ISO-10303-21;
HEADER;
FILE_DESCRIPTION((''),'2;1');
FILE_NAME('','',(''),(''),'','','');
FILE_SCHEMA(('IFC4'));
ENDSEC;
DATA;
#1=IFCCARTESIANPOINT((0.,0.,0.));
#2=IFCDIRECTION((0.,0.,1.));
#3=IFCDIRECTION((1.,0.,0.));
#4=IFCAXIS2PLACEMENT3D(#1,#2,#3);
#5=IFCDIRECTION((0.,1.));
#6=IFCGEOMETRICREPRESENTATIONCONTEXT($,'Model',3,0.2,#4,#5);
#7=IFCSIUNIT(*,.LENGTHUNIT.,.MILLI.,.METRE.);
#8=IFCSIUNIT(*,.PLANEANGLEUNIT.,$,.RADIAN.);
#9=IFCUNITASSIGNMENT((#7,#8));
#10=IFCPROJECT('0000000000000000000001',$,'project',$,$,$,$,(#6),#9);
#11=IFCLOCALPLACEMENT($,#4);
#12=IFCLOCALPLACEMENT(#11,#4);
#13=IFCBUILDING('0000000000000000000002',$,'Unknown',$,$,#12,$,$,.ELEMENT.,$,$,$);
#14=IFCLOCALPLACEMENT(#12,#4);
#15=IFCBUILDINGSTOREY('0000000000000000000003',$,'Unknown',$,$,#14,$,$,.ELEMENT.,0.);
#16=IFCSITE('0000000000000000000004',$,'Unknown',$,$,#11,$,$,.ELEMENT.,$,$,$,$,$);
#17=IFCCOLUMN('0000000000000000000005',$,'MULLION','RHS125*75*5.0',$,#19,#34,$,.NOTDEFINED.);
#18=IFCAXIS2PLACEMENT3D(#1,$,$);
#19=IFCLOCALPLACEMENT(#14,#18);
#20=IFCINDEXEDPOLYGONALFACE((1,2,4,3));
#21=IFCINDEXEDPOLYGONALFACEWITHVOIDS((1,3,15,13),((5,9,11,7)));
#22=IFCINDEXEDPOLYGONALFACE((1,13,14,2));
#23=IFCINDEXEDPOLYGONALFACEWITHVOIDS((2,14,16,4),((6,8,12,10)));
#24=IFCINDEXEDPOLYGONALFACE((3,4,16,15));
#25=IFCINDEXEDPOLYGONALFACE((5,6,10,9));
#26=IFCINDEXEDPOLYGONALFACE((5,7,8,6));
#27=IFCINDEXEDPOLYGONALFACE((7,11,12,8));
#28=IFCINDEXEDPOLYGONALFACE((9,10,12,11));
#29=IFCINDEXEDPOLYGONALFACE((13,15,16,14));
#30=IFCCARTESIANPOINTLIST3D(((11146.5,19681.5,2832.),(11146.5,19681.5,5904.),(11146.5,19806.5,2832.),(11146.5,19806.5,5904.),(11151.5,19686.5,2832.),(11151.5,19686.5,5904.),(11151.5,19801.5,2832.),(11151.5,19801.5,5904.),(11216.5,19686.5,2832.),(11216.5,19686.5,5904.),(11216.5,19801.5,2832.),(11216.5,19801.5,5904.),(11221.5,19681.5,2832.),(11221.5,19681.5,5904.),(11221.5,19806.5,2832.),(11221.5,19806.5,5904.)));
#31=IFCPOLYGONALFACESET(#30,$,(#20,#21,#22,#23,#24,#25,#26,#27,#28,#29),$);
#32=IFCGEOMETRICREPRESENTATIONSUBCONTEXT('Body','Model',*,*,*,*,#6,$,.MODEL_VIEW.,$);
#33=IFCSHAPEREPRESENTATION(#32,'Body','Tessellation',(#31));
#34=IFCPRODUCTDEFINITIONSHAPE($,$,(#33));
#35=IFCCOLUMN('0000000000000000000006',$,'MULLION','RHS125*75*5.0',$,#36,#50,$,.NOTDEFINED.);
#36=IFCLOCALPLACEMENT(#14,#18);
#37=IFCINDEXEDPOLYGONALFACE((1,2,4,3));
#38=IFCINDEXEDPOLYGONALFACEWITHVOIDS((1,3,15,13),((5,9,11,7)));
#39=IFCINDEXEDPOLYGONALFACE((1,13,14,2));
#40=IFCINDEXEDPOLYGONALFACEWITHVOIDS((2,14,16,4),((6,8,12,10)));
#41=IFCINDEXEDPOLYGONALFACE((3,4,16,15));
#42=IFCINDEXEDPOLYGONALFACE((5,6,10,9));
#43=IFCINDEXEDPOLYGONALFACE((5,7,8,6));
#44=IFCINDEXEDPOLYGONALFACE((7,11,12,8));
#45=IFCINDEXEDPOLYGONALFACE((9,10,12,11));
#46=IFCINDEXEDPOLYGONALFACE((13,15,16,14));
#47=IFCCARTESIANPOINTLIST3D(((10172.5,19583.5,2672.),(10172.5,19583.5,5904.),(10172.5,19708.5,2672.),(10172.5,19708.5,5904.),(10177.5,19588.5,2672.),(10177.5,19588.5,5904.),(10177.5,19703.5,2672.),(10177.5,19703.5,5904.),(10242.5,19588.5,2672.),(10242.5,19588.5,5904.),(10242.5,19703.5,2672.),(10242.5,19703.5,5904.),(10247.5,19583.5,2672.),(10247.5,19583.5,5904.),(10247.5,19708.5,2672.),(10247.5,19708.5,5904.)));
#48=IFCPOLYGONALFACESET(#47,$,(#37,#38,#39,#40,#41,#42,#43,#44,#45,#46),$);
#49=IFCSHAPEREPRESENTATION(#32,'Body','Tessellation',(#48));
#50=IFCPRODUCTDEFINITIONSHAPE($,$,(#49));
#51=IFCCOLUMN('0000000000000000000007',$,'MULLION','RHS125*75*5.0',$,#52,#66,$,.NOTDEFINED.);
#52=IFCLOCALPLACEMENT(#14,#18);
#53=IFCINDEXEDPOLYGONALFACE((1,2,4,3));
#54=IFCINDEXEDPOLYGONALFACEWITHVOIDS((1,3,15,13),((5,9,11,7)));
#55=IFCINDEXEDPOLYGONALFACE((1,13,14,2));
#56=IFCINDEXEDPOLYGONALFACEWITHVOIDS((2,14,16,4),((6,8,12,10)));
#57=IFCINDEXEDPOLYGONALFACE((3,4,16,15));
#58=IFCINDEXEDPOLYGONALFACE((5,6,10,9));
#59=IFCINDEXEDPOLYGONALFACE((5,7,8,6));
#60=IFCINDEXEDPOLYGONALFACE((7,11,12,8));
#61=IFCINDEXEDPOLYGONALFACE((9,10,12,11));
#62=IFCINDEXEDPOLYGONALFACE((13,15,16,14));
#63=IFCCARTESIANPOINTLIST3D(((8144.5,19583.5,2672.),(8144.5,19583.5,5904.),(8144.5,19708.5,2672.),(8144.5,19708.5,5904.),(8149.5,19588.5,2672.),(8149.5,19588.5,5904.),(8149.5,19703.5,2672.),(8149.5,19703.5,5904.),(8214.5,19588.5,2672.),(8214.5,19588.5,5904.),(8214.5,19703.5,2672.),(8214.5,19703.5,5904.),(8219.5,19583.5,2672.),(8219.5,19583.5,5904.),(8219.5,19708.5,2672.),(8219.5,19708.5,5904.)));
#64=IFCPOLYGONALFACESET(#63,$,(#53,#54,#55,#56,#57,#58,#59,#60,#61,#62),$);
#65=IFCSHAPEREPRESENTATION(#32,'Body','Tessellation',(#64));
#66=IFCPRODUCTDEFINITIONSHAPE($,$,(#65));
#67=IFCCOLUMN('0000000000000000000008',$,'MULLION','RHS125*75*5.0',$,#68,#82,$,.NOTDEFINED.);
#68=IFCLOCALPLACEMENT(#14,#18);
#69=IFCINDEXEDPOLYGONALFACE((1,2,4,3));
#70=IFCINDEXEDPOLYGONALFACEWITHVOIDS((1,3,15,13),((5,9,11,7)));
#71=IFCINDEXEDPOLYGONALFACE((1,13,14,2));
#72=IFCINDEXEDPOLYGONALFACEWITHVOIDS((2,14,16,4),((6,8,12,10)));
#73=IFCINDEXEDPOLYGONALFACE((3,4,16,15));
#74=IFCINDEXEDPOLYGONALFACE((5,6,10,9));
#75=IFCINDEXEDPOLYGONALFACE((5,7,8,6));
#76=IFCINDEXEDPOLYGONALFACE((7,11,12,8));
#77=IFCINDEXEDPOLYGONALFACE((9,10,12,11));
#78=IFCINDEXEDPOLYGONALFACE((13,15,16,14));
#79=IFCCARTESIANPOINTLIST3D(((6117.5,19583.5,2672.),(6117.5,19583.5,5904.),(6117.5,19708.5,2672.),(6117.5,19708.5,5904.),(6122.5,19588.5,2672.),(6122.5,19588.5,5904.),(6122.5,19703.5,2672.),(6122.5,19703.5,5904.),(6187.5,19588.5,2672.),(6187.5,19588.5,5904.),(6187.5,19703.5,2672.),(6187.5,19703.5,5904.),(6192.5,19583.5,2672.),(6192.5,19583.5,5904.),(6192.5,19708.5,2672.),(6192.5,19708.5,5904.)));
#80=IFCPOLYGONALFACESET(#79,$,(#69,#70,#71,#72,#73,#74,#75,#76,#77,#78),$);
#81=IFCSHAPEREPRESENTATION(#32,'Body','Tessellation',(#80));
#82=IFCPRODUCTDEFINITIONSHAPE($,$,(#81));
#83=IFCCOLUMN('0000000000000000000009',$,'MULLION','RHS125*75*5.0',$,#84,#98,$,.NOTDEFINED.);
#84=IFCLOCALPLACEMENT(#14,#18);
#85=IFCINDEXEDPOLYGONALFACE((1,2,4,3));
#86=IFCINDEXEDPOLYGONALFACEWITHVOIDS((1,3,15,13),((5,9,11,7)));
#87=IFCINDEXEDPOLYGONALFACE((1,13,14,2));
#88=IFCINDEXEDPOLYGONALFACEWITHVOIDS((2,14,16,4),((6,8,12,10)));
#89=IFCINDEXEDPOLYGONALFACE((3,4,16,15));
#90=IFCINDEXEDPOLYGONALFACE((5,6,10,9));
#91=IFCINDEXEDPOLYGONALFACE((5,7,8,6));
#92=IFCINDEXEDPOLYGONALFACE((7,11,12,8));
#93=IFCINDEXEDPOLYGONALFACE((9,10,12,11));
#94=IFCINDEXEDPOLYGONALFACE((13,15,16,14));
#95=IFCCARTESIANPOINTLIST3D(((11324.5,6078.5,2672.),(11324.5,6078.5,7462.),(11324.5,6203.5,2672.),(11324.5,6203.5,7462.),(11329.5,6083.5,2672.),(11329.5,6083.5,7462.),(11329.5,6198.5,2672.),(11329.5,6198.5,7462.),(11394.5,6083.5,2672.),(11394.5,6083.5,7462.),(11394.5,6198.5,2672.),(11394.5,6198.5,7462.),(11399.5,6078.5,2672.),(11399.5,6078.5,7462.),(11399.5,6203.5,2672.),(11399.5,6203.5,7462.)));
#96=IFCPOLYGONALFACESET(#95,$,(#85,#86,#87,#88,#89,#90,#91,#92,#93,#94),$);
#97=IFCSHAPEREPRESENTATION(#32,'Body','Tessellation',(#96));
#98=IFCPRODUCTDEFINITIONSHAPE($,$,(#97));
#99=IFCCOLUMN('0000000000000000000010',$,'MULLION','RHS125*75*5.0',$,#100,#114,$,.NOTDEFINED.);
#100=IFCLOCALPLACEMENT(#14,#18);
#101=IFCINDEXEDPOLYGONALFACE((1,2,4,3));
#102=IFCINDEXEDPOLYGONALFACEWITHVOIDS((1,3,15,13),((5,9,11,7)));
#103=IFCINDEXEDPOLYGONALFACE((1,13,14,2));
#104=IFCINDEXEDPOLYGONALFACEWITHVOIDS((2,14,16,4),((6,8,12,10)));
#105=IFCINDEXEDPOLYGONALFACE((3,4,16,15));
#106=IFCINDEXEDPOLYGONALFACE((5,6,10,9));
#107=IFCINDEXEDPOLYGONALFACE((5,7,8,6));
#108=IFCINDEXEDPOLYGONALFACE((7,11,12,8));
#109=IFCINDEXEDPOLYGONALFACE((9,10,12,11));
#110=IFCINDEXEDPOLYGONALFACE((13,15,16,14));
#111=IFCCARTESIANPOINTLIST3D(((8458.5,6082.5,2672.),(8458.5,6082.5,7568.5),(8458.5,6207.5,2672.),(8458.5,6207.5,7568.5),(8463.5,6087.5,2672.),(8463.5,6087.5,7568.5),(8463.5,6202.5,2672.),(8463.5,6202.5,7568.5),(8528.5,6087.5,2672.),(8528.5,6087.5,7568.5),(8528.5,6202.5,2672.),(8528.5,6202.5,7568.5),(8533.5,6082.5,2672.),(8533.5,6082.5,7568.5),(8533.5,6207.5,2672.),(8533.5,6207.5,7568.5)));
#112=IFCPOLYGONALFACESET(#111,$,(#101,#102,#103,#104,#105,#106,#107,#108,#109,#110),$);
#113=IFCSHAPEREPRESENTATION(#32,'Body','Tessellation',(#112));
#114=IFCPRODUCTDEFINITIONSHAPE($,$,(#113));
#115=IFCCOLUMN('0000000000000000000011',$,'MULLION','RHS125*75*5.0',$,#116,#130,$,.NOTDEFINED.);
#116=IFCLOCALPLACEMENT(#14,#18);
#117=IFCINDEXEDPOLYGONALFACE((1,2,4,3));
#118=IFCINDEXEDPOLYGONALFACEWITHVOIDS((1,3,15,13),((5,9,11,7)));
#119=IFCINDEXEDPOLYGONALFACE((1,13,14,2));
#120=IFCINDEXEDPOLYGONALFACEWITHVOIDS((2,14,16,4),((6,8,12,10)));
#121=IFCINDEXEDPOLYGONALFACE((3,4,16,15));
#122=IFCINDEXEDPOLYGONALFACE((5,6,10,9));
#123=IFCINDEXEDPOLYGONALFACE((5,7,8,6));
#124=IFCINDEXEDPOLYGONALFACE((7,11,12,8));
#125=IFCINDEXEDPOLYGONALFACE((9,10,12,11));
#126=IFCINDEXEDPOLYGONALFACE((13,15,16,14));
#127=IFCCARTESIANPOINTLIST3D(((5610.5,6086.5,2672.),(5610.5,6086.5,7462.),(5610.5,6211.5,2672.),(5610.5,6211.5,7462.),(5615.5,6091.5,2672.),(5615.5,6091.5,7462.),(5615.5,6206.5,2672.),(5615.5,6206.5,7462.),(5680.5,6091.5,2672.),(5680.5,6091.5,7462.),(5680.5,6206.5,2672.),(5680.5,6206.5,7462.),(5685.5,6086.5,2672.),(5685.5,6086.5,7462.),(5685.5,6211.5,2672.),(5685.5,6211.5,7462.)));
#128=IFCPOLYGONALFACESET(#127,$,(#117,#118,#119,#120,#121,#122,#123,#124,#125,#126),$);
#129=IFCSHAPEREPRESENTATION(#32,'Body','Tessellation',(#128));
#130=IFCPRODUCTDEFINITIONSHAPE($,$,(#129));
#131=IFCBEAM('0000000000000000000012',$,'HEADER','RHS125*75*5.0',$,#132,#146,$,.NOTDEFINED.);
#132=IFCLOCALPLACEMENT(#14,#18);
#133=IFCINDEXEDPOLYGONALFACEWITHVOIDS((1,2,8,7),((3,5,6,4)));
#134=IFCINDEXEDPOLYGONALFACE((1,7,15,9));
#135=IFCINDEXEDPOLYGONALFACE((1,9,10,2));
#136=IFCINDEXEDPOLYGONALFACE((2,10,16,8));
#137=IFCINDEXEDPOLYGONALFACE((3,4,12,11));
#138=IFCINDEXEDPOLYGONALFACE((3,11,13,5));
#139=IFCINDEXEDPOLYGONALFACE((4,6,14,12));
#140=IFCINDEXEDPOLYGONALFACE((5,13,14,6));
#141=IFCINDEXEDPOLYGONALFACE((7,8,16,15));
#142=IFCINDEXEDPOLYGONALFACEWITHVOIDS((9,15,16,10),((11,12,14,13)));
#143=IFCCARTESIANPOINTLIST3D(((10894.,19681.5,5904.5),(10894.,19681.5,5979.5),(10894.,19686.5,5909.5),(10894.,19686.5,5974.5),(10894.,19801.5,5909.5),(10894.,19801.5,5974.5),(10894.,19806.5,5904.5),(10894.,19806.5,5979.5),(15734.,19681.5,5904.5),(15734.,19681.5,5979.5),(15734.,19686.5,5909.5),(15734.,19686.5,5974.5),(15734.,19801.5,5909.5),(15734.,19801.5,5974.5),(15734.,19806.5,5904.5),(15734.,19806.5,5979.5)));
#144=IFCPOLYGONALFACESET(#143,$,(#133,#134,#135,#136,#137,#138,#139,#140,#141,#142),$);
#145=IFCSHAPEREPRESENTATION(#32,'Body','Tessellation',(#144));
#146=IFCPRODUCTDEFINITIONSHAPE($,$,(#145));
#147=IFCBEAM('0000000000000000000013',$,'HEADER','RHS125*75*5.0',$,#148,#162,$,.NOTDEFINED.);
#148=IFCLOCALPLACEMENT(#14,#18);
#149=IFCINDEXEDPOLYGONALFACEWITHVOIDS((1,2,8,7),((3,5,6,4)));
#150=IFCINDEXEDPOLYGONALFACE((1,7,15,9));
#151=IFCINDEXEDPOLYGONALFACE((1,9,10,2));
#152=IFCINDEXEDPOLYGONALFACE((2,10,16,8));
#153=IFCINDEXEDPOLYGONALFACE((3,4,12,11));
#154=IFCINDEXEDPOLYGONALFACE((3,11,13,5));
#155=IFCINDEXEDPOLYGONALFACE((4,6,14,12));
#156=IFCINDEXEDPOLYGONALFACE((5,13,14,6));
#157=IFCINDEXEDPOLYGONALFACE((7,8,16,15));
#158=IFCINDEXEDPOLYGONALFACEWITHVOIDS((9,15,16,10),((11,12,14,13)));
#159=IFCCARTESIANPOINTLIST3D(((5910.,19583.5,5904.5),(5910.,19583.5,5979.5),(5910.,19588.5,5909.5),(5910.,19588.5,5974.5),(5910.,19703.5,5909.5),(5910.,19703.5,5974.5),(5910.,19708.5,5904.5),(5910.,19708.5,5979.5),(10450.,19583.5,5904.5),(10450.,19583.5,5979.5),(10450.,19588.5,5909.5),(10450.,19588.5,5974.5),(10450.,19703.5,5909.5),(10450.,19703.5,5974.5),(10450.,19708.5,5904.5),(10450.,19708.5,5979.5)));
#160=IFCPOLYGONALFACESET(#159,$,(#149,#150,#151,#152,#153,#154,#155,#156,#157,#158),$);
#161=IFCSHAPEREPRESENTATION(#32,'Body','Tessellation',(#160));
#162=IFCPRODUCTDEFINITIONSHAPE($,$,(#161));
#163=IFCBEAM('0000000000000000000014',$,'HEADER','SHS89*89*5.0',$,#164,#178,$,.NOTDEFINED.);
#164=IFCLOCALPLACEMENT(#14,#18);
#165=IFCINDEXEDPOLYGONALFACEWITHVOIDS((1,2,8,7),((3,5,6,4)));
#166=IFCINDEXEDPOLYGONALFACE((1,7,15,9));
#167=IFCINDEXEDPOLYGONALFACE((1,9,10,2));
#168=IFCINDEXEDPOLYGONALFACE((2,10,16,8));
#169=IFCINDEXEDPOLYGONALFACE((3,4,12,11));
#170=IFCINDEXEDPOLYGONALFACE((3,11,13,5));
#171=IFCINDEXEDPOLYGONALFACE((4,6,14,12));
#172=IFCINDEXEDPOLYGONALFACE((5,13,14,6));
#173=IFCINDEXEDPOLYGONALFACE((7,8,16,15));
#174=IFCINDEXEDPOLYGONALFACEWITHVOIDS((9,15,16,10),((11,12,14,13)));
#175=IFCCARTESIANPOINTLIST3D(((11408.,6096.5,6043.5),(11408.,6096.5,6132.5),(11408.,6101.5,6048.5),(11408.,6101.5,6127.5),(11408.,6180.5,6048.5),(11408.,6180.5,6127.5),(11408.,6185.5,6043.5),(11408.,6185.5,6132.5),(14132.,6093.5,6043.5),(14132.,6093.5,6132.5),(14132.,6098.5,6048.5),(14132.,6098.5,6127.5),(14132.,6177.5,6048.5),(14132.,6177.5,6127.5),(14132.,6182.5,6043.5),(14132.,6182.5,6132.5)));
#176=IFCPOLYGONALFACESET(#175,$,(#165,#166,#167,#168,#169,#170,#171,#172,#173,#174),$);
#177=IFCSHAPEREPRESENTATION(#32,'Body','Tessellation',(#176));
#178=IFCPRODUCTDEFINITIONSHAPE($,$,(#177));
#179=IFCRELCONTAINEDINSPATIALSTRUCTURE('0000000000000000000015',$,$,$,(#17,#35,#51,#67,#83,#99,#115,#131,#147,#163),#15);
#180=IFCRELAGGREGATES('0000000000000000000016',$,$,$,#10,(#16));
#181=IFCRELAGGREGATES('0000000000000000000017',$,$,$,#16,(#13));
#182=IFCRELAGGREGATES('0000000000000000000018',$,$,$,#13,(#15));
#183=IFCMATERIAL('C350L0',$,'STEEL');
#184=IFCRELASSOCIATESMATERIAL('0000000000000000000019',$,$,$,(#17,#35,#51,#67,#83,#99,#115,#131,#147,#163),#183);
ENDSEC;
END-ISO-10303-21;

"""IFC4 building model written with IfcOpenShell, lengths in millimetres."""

from ifc_helpers import new_model, si_unit, direction, frame, origin_with_axes, place, context, subcontext, project, spatial, line, indexed_curve, outline, extrude, material, element, save


model = new_model("IFC4")

# Units and contexts
model_context = context("Model", 3, precision=0.2, world=origin_with_axes(), true_north=direction((0.0, 1.0)))
body_context = subcontext(model_context, "Body", "Model", "MODEL_VIEW")
ifc_project = project(units=[si_unit("LENGTHUNIT", "METRE", prefix="MILLI"), si_unit("PLANEANGLEUNIT", "RADIAN")], contexts=[model_context])

# Site, building, storey
site_placement = place(None, origin_with_axes())
site = spatial("IfcSite", under=ifc_project, at=site_placement, Name="Unknown", CompositionType="ELEMENT")
building_placement = place(site_placement, origin_with_axes())
building = spatial("IfcBuilding", under=site, at=building_placement, Name="Unknown", CompositionType="ELEMENT")
storey_placement = place(building_placement, origin_with_axes())
storey = spatial("IfcBuildingStorey", under=building, at=storey_placement, Name="Unknown", CompositionType="ELEMENT", Elevation=0.0)

# Columns
ifc_material_1 = material(Name="C350L0", Category="STEEL")
column_1_placement = place(storey_placement, frame((11184.0, 19744.0, 2832.0), z_axis=(1.0, 0.0, 0.0), x_axis=(0.0, 0.0, 1.0)))
element("IfcColumn", 1, at=column_1_placement, inside=storey, material=ifc_material_1, Name="MULLION", Description="RHS125*75*5.0", PredefinedType="NOTDEFINED", context=body_context, shape_type="SolidModel", body=[
    extrude(outline(indexed_curve([(-37.5, -62.5), (37.5, -62.5), (37.5, 62.5), (-37.5, 62.5)], segments=[line(1, 2, 3, 4, 1)]), holes=[indexed_curve([(-32.5, -57.5), (-32.5, 57.5), (32.5, 57.5), (32.5, -57.5)], segments=[line(1, 2, 3, 4, 1)])]), frame((0.0, 0.0, 0.0), z_axis=(-1.0, 0.0, 0.0), x_axis=(0.0, 0.0, 1.0)), (0.0, 0.0, -1.0), 3072.0),
])
for number, where, z_axis, x_axis, name in (
    (2, (10210.0, 19646.0, 2672.0), (1.0, 0.0, 0.0), (0.0, 0.0, 1.0), "MULLION"),
    (3, (8182.0, 19646.0, 2672.0), (1.0, 0.0, 0.0), (0.0, 0.0, 1.0), "MULLION"),
    (4, (6155.0, 19646.0, 2672.0), (1.0, 0.0, 0.0), (0.0, 0.0, 1.0), "MULLION"),
):
    element("IfcColumn", number, at=place(storey_placement, frame(where, z_axis=z_axis, x_axis=x_axis)), inside=storey, material=ifc_material_1, Name=name, Description="RHS125*75*5.0", PredefinedType="NOTDEFINED", context=body_context, shape_type="SolidModel", body=[
        extrude(outline(indexed_curve([(-37.5, -62.5), (37.5, -62.5), (37.5, 62.5), (-37.5, 62.5)], segments=[line(1, 2, 3, 4, 1)]), holes=[indexed_curve([(-32.5, -57.5), (-32.5, 57.5), (32.5, 57.5), (32.5, -57.5)], segments=[line(1, 2, 3, 4, 1)])]), frame((0.0, 0.0, 0.0), z_axis=(-1.0, 0.0, 0.0), x_axis=(0.0, 0.0, 1.0)), (0.0, 0.0, -1.0), 3232.0),
    ])
column_2_placement = place(storey_placement, frame((11362.0, 6141.0, 2672.0), z_axis=(1.0, 0.0, 0.0), x_axis=(0.0, 0.0, 1.0)))
element("IfcColumn", 5, at=column_2_placement, inside=storey, material=ifc_material_1, Name="MULLION", Description="RHS125*75*5.0", PredefinedType="NOTDEFINED", context=body_context, shape_type="SolidModel", body=[
    extrude(outline(indexed_curve([(-37.5, -62.5), (37.5, -62.5), (37.5, 62.5), (-37.5, 62.5)], segments=[line(1, 2, 3, 4, 1)]), holes=[indexed_curve([(-32.5, -57.5), (-32.5, 57.5), (32.5, 57.5), (32.5, -57.5)], segments=[line(1, 2, 3, 4, 1)])]), frame((0.0, 0.0, 0.0), z_axis=(-1.0, 0.0, 0.0), x_axis=(0.0, 0.0, 1.0)), (0.0, 0.0, -1.0), 4790.0),
])
column_3_placement = place(storey_placement, frame((8496.0, 6145.0, 2672.0), z_axis=(1.0, 0.0, 0.0), x_axis=(0.0, 0.0, 1.0)))
element("IfcColumn", 6, at=column_3_placement, inside=storey, material=ifc_material_1, Name="MULLION", Description="RHS125*75*5.0", PredefinedType="NOTDEFINED", context=body_context, shape_type="SolidModel", body=[
    extrude(outline(indexed_curve([(-37.5, -62.5), (37.5, -62.5), (37.5, 62.5), (-37.5, 62.5)], segments=[line(1, 2, 3, 4, 1)]), holes=[indexed_curve([(-32.5, -57.5), (-32.5, 57.5), (32.5, 57.5), (32.5, -57.5)], segments=[line(1, 2, 3, 4, 1)])]), frame((0.0, 0.0, 0.0), z_axis=(-1.0, 0.0, 0.0), x_axis=(0.0, 0.0, 1.0)), (0.0, 0.0, -1.0), 4896.5),
])
column_4_placement = place(storey_placement, frame((5648.0, 6149.0, 2672.0), z_axis=(1.0, 0.0, 0.0), x_axis=(0.0, 0.0, 1.0)))
element("IfcColumn", 7, at=column_4_placement, inside=storey, material=ifc_material_1, Name="MULLION", Description="RHS125*75*5.0", PredefinedType="NOTDEFINED", context=body_context, shape_type="SolidModel", body=[
    extrude(outline(indexed_curve([(-37.5, -62.5), (37.5, -62.5), (37.5, 62.5), (-37.5, 62.5)], segments=[line(1, 2, 3, 4, 1)]), holes=[indexed_curve([(-32.5, -57.5), (-32.5, 57.5), (32.5, 57.5), (32.5, -57.5)], segments=[line(1, 2, 3, 4, 1)])]), frame((0.0, 0.0, 0.0), z_axis=(-1.0, 0.0, 0.0), x_axis=(0.0, 0.0, 1.0)), (0.0, 0.0, -1.0), 4790.0),
])

# Beams
beam_1_placement = place(storey_placement, frame((10894.0, 19744.0, 5942.0), z_axis=(0.0, 0.0, 1.0), x_axis=(1.0, 0.0, 0.0)))
element("IfcBeam", 8, at=beam_1_placement, inside=storey, material=ifc_material_1, Name="HEADER", Description="RHS125*75*5.0", PredefinedType="NOTDEFINED", context=body_context, shape_type="SolidModel", body=[
    extrude(outline(indexed_curve([(-37.5, -62.5), (37.5, -62.5), (37.5, 62.5), (-37.5, 62.5)], segments=[line(1, 2, 3, 4, 1)]), holes=[indexed_curve([(-32.5, -57.5), (-32.5, 57.5), (32.5, 57.5), (32.5, -57.5)], segments=[line(1, 2, 3, 4, 1)])]), frame((0.0, 0.0, 0.0), z_axis=(-1.0, 0.0, 0.0), x_axis=(0.0, 0.0, 1.0)), (0.0, 0.0, -1.0), 4840.0),
])
beam_2_placement = place(storey_placement, frame((5910.0, 19646.0, 5942.0), z_axis=(0.0, 0.0, 1.0), x_axis=(1.0, 0.0, 0.0)))
element("IfcBeam", 9, at=beam_2_placement, inside=storey, material=ifc_material_1, Name="HEADER", Description="RHS125*75*5.0", PredefinedType="NOTDEFINED", context=body_context, shape_type="SolidModel", body=[
    extrude(outline(indexed_curve([(-37.5, -62.5), (37.5, -62.5), (37.5, 62.5), (-37.5, 62.5)], segments=[line(1, 2, 3, 4, 1)]), holes=[indexed_curve([(-32.5, -57.5), (-32.5, 57.5), (32.5, 57.5), (32.5, -57.5)], segments=[line(1, 2, 3, 4, 1)])]), frame((0.0, 0.0, 0.0), z_axis=(-1.0, 0.0, 0.0), x_axis=(0.0, 0.0, 1.0)), (0.0, 0.0, -1.0), 4540.0),
])
beam_3_placement = place(storey_placement, frame((11408.0, 6141.0, 6088.0), z_axis=(0.0, 0.0, 1.0), x_axis=(0.999999, -0.001101, 0.0)))
element("IfcBeam", 10, at=beam_3_placement, inside=storey, material=ifc_material_1, Name="HEADER", Description="SHS89*89*5.0", PredefinedType="NOTDEFINED", context=body_context, shape_type="SolidModel", body=[
    extrude(outline(indexed_curve([(-44.5, -44.5), (44.5, -44.5), (44.5, 44.5), (-44.5, 44.5)], segments=[line(1, 2, 3, 4, 1)]), holes=[indexed_curve([(-39.5, -39.5), (-39.5, 39.5), (39.5, 39.5), (39.5, -39.5)], segments=[line(1, 2, 3, 4, 1)])]), frame((0.0, 0.0, 0.0), z_axis=(-1.0, 0.0, 0.0), x_axis=(0.0, 0.0, 1.0)), (0.0, 0.0, -1.0), 2724.0),
])

save(model, "model.ifc")
